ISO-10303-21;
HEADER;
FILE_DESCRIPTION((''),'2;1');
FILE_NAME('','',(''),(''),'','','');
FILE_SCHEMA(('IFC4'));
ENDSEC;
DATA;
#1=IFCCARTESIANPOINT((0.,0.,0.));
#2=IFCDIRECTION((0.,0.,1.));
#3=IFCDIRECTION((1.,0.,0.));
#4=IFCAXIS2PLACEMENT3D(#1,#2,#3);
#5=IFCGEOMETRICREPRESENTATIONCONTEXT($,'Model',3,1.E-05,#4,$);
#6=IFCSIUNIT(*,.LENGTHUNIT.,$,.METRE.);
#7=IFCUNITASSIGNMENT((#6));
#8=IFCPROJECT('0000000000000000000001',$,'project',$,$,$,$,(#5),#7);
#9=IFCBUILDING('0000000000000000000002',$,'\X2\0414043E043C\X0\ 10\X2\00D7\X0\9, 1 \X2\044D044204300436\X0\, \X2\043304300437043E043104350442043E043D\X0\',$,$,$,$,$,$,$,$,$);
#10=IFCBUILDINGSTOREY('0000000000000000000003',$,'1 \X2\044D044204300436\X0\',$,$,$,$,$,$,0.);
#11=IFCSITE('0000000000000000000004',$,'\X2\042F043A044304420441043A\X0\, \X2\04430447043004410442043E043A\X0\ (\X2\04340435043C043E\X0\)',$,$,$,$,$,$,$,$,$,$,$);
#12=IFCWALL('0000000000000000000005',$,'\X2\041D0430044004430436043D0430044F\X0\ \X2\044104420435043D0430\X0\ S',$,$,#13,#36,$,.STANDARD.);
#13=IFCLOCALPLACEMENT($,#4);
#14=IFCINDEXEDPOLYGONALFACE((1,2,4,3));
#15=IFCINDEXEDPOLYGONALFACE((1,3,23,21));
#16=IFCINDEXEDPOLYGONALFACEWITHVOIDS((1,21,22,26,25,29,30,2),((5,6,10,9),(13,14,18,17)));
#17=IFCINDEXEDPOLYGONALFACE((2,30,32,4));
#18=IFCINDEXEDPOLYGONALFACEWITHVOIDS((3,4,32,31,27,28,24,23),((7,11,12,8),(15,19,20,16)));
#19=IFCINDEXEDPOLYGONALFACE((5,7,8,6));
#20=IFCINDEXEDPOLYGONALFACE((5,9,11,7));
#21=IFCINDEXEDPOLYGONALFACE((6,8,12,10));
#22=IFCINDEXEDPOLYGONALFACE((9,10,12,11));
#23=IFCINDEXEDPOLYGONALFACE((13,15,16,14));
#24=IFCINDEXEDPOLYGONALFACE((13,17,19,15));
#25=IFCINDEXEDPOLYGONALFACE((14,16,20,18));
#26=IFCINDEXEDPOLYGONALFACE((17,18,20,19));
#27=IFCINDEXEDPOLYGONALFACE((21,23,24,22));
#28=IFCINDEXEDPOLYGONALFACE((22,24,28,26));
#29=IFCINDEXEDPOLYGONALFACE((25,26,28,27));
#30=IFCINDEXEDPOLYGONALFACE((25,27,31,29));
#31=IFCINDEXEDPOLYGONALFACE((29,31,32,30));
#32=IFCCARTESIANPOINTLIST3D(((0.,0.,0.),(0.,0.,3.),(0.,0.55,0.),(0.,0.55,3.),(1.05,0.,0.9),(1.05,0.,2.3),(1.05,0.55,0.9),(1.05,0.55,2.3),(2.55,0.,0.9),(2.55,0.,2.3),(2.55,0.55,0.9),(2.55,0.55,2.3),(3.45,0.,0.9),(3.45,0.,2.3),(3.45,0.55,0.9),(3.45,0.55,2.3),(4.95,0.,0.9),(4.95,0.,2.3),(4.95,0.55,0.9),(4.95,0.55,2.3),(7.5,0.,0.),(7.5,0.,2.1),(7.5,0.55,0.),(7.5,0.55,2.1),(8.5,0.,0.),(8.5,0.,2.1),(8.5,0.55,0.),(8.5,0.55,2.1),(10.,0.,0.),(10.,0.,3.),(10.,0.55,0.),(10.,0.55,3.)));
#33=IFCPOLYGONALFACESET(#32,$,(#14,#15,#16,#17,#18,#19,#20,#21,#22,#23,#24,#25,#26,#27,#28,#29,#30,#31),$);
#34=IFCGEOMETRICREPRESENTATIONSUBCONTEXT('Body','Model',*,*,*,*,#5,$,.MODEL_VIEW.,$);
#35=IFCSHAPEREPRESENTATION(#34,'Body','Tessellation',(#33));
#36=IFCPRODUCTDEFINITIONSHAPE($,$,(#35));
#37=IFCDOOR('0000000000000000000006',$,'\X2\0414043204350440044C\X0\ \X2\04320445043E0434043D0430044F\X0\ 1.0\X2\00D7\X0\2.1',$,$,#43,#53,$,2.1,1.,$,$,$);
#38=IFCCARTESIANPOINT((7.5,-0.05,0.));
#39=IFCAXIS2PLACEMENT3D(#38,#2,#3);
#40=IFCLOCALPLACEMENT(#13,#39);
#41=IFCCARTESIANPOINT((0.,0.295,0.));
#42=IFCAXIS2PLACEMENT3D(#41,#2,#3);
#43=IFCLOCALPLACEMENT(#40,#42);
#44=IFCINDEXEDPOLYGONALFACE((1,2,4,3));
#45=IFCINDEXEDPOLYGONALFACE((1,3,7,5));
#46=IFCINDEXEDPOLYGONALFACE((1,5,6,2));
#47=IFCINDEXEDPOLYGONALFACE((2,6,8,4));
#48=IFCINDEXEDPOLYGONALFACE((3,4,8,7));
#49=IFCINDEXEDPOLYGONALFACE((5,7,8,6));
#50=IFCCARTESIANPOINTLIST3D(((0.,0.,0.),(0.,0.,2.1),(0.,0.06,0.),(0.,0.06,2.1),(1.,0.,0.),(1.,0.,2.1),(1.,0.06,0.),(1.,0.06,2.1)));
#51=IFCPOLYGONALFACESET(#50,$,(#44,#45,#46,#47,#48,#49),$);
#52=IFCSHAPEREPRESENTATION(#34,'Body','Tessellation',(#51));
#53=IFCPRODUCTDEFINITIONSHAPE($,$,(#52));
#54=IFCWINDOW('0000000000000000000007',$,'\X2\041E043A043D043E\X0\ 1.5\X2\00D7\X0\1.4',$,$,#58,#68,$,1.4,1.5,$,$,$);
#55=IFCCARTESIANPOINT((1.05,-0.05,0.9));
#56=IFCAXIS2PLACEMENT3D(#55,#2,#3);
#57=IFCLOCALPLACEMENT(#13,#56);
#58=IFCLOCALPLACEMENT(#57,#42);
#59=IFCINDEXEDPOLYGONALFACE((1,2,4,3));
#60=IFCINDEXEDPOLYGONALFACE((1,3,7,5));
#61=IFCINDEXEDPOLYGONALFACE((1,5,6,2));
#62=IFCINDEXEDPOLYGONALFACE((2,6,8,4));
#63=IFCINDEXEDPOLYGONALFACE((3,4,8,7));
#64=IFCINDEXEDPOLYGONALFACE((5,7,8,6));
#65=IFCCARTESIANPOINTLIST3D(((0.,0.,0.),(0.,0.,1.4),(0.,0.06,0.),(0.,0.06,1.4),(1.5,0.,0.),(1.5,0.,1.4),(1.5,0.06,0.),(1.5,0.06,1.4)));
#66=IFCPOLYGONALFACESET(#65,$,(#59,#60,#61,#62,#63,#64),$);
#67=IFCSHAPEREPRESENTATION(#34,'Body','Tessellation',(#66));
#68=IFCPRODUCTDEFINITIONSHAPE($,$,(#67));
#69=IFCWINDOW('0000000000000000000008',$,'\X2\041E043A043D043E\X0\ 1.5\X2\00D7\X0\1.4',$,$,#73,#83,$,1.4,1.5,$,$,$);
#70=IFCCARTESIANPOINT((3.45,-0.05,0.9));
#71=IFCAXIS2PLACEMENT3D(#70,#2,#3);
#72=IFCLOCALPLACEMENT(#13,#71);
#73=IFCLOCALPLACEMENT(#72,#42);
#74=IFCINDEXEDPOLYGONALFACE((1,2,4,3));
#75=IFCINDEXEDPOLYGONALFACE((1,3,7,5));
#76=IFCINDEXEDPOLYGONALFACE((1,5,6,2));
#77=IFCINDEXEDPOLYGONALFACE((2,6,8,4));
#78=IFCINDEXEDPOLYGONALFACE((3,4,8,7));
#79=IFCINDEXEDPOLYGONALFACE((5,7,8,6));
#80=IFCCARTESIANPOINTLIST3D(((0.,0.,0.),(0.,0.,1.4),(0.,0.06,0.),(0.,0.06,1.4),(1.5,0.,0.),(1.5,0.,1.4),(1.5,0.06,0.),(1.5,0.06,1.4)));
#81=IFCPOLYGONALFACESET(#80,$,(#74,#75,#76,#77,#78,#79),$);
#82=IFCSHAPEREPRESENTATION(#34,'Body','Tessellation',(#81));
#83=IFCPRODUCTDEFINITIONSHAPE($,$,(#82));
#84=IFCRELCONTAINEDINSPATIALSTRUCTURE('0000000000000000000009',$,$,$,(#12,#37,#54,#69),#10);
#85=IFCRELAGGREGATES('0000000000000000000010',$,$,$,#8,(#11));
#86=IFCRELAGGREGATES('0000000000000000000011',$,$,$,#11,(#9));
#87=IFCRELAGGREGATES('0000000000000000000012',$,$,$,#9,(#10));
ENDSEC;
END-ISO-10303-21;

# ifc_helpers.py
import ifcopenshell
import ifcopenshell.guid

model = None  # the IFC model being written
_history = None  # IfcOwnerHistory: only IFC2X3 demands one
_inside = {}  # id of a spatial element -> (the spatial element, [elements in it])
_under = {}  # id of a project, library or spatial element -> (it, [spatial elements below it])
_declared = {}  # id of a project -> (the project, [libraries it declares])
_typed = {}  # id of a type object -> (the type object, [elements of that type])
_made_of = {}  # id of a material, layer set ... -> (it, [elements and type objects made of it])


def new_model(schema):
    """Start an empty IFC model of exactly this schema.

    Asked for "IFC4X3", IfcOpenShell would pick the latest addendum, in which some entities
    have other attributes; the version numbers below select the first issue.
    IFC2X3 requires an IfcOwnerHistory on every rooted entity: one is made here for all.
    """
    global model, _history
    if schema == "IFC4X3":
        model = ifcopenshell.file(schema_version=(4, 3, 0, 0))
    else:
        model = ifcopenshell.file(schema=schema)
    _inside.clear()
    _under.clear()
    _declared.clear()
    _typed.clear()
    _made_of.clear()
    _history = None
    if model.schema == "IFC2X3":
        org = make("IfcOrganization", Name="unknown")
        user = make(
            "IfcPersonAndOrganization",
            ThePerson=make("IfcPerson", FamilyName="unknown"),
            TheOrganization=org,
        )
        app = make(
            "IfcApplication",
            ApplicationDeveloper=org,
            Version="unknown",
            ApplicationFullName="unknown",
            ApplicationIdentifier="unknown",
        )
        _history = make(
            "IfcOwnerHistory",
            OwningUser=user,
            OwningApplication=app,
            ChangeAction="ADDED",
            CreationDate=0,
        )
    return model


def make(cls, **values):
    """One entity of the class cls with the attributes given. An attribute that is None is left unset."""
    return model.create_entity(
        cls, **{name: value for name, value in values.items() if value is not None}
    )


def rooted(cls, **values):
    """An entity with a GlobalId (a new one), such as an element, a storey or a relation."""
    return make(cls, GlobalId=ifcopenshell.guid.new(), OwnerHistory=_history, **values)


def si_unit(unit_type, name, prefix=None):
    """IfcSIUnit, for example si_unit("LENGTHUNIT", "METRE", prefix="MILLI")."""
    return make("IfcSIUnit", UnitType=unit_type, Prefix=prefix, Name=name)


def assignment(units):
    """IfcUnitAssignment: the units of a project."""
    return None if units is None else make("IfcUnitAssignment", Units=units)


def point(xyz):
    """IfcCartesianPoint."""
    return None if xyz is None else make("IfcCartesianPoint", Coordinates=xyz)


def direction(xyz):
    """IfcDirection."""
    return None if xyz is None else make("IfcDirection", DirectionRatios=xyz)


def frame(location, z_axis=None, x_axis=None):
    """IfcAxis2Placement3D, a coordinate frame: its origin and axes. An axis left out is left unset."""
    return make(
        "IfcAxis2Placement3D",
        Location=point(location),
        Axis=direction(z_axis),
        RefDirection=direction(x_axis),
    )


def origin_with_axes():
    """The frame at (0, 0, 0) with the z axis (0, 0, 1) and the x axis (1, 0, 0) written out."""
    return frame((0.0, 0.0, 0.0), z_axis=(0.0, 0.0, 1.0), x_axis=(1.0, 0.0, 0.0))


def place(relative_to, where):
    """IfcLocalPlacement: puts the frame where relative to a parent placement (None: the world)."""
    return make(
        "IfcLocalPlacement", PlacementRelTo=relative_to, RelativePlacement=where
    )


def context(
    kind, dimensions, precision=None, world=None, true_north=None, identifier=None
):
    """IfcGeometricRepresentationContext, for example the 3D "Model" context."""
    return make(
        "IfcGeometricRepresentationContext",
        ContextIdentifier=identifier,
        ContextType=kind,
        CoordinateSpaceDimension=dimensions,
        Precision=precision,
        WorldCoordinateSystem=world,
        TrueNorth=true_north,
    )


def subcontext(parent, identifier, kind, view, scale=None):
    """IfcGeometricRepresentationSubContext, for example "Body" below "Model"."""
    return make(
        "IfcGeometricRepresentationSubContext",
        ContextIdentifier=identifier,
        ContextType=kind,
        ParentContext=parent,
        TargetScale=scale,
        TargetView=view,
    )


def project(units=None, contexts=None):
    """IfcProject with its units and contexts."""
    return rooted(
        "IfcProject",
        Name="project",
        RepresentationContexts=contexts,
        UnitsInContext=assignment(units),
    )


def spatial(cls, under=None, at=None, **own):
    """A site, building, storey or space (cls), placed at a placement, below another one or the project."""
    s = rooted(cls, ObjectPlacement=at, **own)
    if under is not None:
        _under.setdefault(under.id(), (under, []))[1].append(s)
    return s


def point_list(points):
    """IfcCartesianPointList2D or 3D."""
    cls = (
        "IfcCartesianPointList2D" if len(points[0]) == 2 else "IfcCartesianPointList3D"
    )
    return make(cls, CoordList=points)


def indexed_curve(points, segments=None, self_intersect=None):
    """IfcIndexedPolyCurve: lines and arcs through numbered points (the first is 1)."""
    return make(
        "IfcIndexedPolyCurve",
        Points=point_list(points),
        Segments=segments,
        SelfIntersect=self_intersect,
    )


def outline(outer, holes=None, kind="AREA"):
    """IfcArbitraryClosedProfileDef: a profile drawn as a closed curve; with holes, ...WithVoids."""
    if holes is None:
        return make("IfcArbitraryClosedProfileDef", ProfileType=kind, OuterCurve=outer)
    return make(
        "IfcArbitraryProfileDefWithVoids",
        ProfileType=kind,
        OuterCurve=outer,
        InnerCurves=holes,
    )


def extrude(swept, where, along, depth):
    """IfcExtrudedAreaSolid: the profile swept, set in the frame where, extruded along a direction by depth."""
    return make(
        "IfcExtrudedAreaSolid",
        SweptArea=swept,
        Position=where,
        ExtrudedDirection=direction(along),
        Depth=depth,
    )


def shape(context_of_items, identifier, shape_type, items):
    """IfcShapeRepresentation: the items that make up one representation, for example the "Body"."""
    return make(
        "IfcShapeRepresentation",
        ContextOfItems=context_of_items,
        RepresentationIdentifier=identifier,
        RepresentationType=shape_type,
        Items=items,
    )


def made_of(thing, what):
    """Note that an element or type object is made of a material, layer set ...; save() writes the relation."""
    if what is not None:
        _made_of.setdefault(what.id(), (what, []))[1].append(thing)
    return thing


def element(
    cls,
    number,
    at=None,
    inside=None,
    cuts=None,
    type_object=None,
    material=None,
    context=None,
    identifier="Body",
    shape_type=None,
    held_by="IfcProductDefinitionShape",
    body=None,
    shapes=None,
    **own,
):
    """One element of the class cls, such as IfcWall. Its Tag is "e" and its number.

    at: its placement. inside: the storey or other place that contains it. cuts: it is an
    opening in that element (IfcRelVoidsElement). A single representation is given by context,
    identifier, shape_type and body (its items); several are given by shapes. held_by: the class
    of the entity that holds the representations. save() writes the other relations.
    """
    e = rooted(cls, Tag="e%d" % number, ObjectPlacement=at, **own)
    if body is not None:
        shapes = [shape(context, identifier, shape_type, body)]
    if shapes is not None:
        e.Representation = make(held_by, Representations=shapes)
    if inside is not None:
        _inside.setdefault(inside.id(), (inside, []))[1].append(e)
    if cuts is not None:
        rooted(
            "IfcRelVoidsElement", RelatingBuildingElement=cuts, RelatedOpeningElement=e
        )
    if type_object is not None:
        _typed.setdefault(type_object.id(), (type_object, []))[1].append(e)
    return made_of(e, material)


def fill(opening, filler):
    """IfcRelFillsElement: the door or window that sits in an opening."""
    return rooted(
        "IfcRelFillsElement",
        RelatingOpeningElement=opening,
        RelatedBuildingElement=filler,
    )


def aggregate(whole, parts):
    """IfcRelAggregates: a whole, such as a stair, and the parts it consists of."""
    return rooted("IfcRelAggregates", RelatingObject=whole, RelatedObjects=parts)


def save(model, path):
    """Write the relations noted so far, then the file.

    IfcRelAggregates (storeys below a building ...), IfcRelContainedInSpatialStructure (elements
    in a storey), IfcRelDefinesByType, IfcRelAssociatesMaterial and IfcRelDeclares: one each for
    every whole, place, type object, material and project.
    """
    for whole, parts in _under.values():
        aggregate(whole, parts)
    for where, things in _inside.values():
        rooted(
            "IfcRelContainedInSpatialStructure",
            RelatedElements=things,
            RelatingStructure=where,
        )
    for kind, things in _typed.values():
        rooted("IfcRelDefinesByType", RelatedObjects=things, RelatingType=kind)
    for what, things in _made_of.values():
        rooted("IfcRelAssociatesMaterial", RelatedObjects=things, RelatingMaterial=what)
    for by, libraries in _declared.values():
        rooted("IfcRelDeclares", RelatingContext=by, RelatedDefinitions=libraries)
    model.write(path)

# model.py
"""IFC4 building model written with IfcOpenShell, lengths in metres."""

from ifc_helpers import new_model, si_unit, frame, origin_with_axes, place, context, subcontext, project, spatial, indexed_curve, outline, extrude, element, fill, save


model = new_model("IFC4")

# Units and contexts
model_context = context("Model", 3, precision=1e-05, world=origin_with_axes())
body_context = subcontext(model_context, "Body", "Model", "MODEL_VIEW")
ifc_project = project(units=[si_unit("LENGTHUNIT", "METRE")], contexts=[model_context])

# Site, building, storey
site = spatial("IfcSite", under=ifc_project, Name="Якутск, участок (демо)")
building = spatial("IfcBuilding", under=site, Name="Дом 10×9, 1 этаж, газобетон")
storey = spatial("IfcBuildingStorey", under=building, Name="1 этаж", Elevation=0.0)

# Wall, openings, door, windows
wall_1_placement = place(None, origin_with_axes())
wall_1 = element("IfcWall", 1, at=wall_1_placement, inside=storey, Name="Наружная стена S", PredefinedType="STANDARD", context=body_context, shape_type="SweptSolid", body=[
    extrude(outline(indexed_curve([(0.0, 0.0), (0.0, 0.55), (10.0, 0.55), (10.0, 0.0), (0.0, 0.0)], self_intersect=False)), origin_with_axes(), (0.0, 0.0, 1.0), 3.0),
])
opening_1_placement = place(wall_1_placement, frame((7.5, -0.05, 0.0), z_axis=(0.0, 0.0, 1.0), x_axis=(1.0, 0.0, 0.0)))
opening_1 = element("IfcOpeningElement", 2, at=opening_1_placement, cuts=wall_1, context=body_context, shape_type="SweptSolid", body=[
    extrude(outline(indexed_curve([(0.0, 0.0), (0.0, 0.65), (1.0, 0.65), (1.0, 0.0), (0.0, 0.0)], self_intersect=False)), origin_with_axes(), (0.0, 0.0, 1.0), 2.1),
])
opening_2_placement = place(wall_1_placement, frame((1.05, -0.05, 0.9), z_axis=(0.0, 0.0, 1.0), x_axis=(1.0, 0.0, 0.0)))
opening_2 = element("IfcOpeningElement", 3, at=opening_2_placement, cuts=wall_1, context=body_context, shape_type="SweptSolid", body=[
    extrude(outline(indexed_curve([(0.0, 0.0), (0.0, 0.65), (1.5, 0.65), (1.5, 0.0), (0.0, 0.0)], self_intersect=False)), origin_with_axes(), (0.0, 0.0, 1.0), 1.4),
])
opening_3_placement = place(wall_1_placement, frame((3.45, -0.05, 0.9), z_axis=(0.0, 0.0, 1.0), x_axis=(1.0, 0.0, 0.0)))
opening_3 = element("IfcOpeningElement", 4, at=opening_3_placement, cuts=wall_1, context=body_context, shape_type="SweptSolid", body=[
    extrude(outline(indexed_curve([(0.0, 0.0), (0.0, 0.65), (1.5, 0.65), (1.5, 0.0), (0.0, 0.0)], self_intersect=False)), origin_with_axes(), (0.0, 0.0, 1.0), 1.4),
])
door_1_placement = place(opening_1_placement, frame((0.0, 0.295, 0.0), z_axis=(0.0, 0.0, 1.0), x_axis=(1.0, 0.0, 0.0)))
door_1 = element("IfcDoor", 5, at=door_1_placement, inside=storey, Name="Дверь входная 1.0×2.1", OverallHeight=2.1, OverallWidth=1.0, context=body_context, shape_type="SweptSolid", body=[
    extrude(outline(indexed_curve([(0.0, 0.0), (0.0, 0.06), (1.0, 0.06), (1.0, 0.0), (0.0, 0.0)], self_intersect=False)), origin_with_axes(), (0.0, 0.0, 1.0), 2.1),
])
fill(opening_1, door_1)
window_1_placement = place(opening_2_placement, frame((0.0, 0.295, 0.0), z_axis=(0.0, 0.0, 1.0), x_axis=(1.0, 0.0, 0.0)))
window_1 = element("IfcWindow", 6, at=window_1_placement, inside=storey, Name="Окно 1.5×1.4", OverallHeight=1.4, OverallWidth=1.5, context=body_context, shape_type="SweptSolid", body=[
    extrude(outline(indexed_curve([(0.0, 0.0), (0.0, 0.06), (1.5, 0.06), (1.5, 0.0), (0.0, 0.0)], self_intersect=False)), origin_with_axes(), (0.0, 0.0, 1.0), 1.4),
])
fill(opening_2, window_1)
window_2_placement = place(opening_3_placement, frame((0.0, 0.295, 0.0), z_axis=(0.0, 0.0, 1.0), x_axis=(1.0, 0.0, 0.0)))
window_2 = element("IfcWindow", 7, at=window_2_placement, inside=storey, Name="Окно 1.5×1.4", OverallHeight=1.4, OverallWidth=1.5, context=body_context, shape_type="SweptSolid", body=[
    extrude(outline(indexed_curve([(0.0, 0.0), (0.0, 0.06), (1.5, 0.06), (1.5, 0.0), (0.0, 0.0)], self_intersect=False)), origin_with_axes(), (0.0, 0.0, 1.0), 1.4),
])
fill(opening_3, window_2)

save(model, "model.ifc")
